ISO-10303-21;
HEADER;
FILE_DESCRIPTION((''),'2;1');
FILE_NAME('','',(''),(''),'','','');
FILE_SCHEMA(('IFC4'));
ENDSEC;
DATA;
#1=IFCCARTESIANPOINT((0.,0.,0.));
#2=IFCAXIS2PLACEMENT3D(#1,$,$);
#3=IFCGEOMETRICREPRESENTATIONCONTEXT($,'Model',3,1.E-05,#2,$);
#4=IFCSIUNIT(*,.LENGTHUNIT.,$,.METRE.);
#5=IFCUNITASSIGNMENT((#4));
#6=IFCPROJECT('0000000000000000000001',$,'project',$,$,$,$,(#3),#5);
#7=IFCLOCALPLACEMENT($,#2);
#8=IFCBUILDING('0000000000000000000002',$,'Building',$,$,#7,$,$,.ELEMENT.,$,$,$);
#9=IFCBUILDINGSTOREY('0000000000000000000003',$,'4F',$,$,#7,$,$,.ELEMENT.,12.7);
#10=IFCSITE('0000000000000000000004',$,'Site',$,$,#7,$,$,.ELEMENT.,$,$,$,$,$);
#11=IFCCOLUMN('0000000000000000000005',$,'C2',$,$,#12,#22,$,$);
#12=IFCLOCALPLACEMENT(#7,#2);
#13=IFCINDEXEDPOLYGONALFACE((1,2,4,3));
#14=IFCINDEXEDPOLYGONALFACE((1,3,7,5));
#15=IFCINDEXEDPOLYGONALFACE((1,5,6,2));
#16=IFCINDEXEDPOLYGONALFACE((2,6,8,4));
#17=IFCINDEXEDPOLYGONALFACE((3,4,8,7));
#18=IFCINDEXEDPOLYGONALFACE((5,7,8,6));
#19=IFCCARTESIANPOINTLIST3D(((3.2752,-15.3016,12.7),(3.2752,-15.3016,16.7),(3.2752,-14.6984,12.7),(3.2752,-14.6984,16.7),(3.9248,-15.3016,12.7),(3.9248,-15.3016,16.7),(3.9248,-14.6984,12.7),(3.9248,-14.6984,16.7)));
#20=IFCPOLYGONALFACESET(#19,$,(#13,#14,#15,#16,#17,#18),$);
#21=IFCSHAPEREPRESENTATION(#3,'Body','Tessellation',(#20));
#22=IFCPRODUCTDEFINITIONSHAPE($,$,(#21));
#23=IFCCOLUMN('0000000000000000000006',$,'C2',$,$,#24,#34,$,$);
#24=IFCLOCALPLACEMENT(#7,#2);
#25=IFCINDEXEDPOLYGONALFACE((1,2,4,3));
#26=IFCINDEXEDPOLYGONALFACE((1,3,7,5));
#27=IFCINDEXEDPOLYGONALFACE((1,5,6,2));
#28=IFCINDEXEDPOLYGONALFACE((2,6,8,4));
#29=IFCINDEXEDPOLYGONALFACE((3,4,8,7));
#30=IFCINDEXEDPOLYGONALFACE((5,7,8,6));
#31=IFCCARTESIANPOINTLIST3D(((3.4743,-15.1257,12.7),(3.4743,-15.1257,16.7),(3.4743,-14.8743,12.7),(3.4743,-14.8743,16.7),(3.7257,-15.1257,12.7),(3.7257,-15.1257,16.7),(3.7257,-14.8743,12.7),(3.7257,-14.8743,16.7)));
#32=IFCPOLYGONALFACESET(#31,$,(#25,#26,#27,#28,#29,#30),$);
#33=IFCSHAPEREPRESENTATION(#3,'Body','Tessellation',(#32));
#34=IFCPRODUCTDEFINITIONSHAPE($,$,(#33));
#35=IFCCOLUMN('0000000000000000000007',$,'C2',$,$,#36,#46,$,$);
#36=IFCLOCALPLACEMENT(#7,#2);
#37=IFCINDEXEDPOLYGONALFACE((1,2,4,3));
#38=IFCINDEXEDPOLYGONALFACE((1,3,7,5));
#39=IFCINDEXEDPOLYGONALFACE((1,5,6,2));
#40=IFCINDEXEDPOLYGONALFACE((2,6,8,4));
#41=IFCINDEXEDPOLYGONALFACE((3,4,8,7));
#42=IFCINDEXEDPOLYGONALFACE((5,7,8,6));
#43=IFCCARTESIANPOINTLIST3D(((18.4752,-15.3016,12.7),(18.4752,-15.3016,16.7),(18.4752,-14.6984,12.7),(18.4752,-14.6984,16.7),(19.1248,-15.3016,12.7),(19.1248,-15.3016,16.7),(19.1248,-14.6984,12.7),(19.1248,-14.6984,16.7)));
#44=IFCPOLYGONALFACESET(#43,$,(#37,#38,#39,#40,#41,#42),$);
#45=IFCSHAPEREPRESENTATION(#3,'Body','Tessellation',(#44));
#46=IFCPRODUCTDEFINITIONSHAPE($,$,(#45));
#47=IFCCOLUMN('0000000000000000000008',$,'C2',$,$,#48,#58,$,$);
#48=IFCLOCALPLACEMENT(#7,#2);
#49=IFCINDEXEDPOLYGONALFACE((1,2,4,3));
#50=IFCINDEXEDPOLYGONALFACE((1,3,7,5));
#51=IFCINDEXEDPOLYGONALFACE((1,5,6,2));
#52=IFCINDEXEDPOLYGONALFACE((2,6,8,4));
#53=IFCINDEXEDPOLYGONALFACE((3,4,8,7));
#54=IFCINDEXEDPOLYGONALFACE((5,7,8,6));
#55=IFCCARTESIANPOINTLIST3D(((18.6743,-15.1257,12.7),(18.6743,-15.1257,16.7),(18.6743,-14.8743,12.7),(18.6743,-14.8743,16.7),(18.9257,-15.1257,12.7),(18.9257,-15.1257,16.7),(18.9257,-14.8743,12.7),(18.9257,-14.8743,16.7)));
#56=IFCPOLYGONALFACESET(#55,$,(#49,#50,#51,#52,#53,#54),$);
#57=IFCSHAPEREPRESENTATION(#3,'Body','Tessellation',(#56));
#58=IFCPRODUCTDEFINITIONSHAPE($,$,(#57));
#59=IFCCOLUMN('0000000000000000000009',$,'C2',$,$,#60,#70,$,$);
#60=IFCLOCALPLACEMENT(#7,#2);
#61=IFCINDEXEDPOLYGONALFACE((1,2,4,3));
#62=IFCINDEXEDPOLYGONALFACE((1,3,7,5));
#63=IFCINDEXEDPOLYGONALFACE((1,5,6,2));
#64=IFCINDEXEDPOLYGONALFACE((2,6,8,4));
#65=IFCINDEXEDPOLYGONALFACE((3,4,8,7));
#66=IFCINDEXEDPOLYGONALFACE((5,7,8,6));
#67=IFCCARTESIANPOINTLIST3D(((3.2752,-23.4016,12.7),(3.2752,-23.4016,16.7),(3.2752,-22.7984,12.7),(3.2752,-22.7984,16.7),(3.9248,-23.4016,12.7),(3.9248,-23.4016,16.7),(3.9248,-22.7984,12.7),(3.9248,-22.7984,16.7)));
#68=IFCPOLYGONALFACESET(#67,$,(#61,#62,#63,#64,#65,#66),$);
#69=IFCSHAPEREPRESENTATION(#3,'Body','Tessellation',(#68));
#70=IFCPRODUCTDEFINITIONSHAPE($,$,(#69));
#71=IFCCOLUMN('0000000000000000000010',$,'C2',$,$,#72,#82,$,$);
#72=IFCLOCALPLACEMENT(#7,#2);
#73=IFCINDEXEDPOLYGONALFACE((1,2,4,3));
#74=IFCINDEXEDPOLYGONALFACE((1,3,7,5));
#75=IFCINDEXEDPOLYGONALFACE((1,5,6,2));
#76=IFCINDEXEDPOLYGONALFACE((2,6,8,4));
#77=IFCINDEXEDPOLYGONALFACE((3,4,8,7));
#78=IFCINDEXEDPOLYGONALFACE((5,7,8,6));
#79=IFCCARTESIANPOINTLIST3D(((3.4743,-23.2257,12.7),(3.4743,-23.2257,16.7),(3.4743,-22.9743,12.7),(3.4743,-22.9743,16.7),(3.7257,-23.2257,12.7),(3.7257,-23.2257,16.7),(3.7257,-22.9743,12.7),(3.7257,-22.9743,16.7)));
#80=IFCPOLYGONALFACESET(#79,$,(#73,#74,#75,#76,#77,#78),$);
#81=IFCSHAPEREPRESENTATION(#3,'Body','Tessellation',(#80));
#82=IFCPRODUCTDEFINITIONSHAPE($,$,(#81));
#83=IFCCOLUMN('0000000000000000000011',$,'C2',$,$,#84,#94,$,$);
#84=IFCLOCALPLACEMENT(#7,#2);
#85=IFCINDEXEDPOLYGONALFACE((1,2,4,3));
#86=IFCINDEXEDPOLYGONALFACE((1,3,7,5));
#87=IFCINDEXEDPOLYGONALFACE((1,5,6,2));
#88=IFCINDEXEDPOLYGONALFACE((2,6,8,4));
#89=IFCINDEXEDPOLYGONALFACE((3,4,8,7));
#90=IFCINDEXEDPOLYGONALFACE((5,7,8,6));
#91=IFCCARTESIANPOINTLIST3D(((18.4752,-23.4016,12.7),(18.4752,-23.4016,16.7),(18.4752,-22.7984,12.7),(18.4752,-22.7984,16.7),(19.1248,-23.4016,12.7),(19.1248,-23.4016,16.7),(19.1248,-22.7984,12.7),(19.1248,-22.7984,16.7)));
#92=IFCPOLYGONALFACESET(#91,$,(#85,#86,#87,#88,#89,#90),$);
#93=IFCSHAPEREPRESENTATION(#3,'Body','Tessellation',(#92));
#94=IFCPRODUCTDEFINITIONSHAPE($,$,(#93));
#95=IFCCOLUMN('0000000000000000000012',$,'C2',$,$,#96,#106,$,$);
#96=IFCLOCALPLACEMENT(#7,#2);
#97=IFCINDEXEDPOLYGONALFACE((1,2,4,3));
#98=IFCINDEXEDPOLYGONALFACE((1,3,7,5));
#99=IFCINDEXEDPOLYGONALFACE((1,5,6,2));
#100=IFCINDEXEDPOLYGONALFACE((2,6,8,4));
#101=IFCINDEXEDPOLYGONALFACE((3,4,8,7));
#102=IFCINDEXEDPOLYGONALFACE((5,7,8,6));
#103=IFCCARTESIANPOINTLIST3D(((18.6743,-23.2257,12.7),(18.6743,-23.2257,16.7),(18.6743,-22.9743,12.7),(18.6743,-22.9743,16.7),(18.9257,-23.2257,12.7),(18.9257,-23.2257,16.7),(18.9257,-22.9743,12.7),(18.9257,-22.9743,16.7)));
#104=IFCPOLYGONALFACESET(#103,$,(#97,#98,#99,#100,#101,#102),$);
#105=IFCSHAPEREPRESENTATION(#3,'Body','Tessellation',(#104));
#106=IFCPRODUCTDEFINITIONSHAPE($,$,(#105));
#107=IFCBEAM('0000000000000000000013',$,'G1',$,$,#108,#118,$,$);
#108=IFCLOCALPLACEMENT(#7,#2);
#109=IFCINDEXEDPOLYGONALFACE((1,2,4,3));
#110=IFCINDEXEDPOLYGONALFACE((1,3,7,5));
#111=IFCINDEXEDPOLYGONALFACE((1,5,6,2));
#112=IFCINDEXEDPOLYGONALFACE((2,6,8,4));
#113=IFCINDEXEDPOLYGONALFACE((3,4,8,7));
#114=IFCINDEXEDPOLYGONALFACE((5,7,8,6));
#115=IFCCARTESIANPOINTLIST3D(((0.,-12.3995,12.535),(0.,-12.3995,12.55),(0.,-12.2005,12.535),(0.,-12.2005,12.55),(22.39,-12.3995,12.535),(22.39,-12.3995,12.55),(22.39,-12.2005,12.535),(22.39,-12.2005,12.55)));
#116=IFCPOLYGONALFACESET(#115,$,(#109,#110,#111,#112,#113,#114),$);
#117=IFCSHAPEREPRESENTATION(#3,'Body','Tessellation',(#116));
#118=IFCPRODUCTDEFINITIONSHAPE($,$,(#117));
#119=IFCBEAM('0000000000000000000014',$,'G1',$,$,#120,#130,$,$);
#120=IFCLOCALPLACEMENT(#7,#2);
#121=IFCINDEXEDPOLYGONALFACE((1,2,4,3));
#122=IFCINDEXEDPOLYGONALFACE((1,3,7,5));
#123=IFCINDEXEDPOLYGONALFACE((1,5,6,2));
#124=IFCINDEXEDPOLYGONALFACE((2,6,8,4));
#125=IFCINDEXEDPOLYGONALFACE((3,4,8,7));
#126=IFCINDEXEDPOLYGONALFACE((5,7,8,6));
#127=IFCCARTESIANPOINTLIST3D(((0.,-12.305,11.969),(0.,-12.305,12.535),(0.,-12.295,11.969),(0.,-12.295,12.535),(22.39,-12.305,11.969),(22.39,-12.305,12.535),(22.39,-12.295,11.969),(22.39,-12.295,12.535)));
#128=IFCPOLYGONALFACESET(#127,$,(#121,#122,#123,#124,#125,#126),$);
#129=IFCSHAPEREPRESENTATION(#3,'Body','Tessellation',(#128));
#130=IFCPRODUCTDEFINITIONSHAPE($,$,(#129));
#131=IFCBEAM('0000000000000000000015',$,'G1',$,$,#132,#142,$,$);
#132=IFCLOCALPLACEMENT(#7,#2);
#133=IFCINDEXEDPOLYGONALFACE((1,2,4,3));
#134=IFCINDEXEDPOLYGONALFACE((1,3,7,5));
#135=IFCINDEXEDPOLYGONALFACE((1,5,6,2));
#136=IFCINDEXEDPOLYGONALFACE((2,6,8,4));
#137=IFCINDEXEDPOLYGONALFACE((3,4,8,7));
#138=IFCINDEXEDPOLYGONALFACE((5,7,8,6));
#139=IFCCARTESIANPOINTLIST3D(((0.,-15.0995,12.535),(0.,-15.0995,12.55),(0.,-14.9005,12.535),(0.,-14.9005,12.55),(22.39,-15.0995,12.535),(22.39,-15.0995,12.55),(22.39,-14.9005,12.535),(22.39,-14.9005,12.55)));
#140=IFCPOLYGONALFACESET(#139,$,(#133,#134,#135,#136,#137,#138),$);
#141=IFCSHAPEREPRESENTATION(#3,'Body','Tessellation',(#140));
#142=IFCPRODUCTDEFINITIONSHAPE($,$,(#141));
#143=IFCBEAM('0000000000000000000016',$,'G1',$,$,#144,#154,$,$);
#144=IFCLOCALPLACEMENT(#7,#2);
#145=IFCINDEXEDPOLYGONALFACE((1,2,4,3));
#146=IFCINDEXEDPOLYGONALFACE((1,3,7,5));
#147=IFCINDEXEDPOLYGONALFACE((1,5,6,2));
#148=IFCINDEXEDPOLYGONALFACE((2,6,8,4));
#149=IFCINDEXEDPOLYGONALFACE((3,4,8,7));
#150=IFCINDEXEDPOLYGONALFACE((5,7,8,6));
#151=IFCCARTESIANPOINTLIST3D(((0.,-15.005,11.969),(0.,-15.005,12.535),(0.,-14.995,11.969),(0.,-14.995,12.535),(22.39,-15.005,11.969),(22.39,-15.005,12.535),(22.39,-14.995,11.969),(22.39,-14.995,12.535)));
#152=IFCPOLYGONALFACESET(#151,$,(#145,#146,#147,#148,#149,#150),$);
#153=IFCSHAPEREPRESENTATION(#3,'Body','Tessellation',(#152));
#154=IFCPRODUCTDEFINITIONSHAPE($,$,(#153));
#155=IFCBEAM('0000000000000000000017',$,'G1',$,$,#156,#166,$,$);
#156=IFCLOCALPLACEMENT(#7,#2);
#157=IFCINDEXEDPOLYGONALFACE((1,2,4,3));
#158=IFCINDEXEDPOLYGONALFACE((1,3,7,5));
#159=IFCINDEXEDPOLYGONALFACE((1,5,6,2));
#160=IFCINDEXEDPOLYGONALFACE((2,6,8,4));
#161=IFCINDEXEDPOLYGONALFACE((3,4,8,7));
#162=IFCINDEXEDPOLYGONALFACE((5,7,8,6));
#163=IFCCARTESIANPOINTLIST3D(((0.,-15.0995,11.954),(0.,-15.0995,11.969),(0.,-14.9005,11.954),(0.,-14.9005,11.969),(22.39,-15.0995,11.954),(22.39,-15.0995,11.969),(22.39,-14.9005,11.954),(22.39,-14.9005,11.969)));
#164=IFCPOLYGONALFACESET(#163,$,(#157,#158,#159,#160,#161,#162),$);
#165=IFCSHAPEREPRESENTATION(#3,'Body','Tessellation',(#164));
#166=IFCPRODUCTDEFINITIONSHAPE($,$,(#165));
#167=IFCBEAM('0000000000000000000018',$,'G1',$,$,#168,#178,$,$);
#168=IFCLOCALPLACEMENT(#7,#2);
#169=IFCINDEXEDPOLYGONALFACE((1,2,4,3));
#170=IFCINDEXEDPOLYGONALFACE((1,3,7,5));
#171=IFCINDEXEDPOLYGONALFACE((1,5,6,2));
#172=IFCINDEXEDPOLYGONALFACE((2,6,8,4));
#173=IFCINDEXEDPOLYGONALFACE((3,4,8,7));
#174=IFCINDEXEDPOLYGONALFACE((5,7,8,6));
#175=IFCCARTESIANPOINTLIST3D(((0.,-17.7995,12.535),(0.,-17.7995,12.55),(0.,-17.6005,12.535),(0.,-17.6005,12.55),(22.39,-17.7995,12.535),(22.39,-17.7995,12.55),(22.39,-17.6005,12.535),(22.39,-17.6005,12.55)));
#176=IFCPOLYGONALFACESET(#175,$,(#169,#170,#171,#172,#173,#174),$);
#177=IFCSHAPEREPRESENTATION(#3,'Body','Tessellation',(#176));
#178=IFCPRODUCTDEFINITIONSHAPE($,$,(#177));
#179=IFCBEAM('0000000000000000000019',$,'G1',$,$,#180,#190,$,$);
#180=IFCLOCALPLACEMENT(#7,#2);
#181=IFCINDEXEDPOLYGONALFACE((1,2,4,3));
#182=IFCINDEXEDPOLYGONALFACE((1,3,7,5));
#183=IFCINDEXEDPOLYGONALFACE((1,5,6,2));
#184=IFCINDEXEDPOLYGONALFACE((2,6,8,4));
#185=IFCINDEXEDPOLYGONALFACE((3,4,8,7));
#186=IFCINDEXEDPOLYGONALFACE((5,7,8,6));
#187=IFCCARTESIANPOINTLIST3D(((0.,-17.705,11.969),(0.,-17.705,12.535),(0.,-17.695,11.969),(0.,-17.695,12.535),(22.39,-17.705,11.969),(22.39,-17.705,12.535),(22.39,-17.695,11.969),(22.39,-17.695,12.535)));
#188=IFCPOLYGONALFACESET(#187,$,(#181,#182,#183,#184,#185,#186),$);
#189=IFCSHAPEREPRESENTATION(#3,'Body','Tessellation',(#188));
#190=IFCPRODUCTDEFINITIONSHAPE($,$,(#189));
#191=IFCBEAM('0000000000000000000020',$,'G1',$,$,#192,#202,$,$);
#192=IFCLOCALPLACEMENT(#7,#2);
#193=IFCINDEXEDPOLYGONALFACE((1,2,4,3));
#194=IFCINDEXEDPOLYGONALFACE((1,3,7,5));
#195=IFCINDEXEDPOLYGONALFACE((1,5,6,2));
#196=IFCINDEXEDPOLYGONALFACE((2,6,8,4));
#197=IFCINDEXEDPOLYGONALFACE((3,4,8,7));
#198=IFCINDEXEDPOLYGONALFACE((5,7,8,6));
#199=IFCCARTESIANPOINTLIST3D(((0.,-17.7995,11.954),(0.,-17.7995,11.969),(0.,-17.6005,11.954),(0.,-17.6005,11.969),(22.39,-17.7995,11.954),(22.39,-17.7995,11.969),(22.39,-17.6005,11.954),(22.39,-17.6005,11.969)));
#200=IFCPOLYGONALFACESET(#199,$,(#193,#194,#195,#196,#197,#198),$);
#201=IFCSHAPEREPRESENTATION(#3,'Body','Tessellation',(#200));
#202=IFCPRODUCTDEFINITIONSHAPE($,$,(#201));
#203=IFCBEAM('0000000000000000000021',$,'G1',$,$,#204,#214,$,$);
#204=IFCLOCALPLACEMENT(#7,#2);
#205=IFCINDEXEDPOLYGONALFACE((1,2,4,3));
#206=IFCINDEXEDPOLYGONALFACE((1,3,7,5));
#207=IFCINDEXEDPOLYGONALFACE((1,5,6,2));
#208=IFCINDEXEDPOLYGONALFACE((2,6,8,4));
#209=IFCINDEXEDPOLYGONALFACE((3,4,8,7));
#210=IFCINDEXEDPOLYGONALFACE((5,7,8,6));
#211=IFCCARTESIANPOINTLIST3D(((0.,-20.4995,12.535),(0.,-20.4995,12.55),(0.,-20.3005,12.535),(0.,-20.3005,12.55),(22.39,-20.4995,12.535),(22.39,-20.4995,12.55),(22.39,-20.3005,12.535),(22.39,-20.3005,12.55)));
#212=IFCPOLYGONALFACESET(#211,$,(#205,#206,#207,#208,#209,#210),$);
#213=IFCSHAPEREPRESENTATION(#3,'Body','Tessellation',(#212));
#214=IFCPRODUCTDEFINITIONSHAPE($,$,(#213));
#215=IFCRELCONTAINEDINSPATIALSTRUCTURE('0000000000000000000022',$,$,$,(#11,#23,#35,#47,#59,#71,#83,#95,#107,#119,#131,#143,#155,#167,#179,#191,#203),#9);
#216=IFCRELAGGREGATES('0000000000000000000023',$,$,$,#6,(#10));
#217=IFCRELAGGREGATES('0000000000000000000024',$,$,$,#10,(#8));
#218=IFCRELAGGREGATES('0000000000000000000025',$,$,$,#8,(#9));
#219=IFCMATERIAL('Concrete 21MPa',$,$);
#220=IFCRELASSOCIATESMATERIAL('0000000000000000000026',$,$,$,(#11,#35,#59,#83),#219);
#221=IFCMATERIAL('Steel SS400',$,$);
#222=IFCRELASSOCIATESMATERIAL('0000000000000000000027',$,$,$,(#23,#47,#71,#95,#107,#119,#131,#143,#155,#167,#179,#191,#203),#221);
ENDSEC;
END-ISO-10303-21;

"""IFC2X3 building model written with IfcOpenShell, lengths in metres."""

from ifc_helpers import new_model, si_unit, frame, origin, origin_2d, place, context, project, spatial, rectangle, extrude, material, element, save


model = new_model("IFC2X3")

# Units and contexts
model_context = context("Model", 3, precision=1e-05, world=origin())
ifc_project = project(units=[si_unit("LENGTHUNIT", "METRE")], contexts=[model_context])

# Site, building, storey
placement = place(None, origin())
site = spatial("IfcSite", under=ifc_project, at=placement, Name="Site", CompositionType="ELEMENT")
building = spatial("IfcBuilding", under=site, at=placement, Name="Building", CompositionType="ELEMENT")
storey = spatial("IfcBuildingStorey", under=building, at=placement, Name="4F", CompositionType="ELEMENT", Elevation=12.7)

# Columns
ifc_material_1 = material(Name="Concrete 21MPa")
column_1_placement = place(None, frame((3.6, -15.0, 12.7)))
element("IfcColumn", 1, at=column_1_placement, inside=storey, material=ifc_material_1, Name="C2", context=model_context, shape_type="SweptSolid", body=[
    extrude(rectangle(XDim=0.6496, YDim=0.6032, at=origin_2d()), origin(), (0.0, 0.0, 1.0), 4.0),
])
ifc_material_2 = material(Name="Steel SS400")
column_2_placement = place(None, frame((3.6, -15.0, 12.7)))
element("IfcColumn", 2, at=column_2_placement, inside=storey, material=ifc_material_2, Name="C2", context=model_context, shape_type="SweptSolid", body=[
    extrude(rectangle(XDim=0.2513, YDim=0.2513, at=origin_2d()), origin(), (0.0, 0.0, 1.0), 4.0),
])
column_3_placement = place(None, frame((18.8, -15.0, 12.7)))
element("IfcColumn", 3, at=column_3_placement, inside=storey, material=ifc_material_1, Name="C2", context=model_context, shape_type="SweptSolid", body=[
    extrude(rectangle(XDim=0.6496, YDim=0.6032, at=origin_2d()), origin(), (0.0, 0.0, 1.0), 4.0),
])
column_4_placement = place(None, frame((18.8, -15.0, 12.7)))
element("IfcColumn", 4, at=column_4_placement, inside=storey, material=ifc_material_2, Name="C2", context=model_context, shape_type="SweptSolid", body=[
    extrude(rectangle(XDim=0.2513, YDim=0.2513, at=origin_2d()), origin(), (0.0, 0.0, 1.0), 4.0),
])
column_5_placement = place(None, frame((3.6, -23.1, 12.7)))
element("IfcColumn", 5, at=column_5_placement, inside=storey, material=ifc_material_1, Name="C2", context=model_context, shape_type="SweptSolid", body=[
    extrude(rectangle(XDim=0.6496, YDim=0.6032, at=origin_2d()), origin(), (0.0, 0.0, 1.0), 4.0),
])
column_6_placement = place(None, frame((3.6, -23.1, 12.7)))
element("IfcColumn", 6, at=column_6_placement, inside=storey, material=ifc_material_2, Name="C2", context=model_context, shape_type="SweptSolid", body=[
    extrude(rectangle(XDim=0.2513, YDim=0.2513, at=origin_2d()), origin(), (0.0, 0.0, 1.0), 4.0),
])
column_7_placement = place(None, frame((18.8, -23.1, 12.7)))
element("IfcColumn", 7, at=column_7_placement, inside=storey, material=ifc_material_1, Name="C2", context=model_context, shape_type="SweptSolid", body=[
    extrude(rectangle(XDim=0.6496, YDim=0.6032, at=origin_2d()), origin(), (0.0, 0.0, 1.0), 4.0),
])
column_8_placement = place(None, frame((18.8, -23.1, 12.7)))
element("IfcColumn", 8, at=column_8_placement, inside=storey, material=ifc_material_2, Name="C2", context=model_context, shape_type="SweptSolid", body=[
    extrude(rectangle(XDim=0.2513, YDim=0.2513, at=origin_2d()), origin(), (0.0, 0.0, 1.0), 4.0),
])

# Beams
beam_1_placement = place(None, frame((11.195, -12.3, 12.535)))
element("IfcBeam", 9, at=beam_1_placement, inside=storey, material=ifc_material_2, Name="G1", context=model_context, shape_type="SweptSolid", body=[
    extrude(rectangle(XDim=22.39, YDim=0.199, at=origin_2d()), origin(), (0.0, 0.0, 1.0), 0.015),
])
beam_2_placement = place(None, frame((11.195, -12.3, 11.969)))
element("IfcBeam", 10, at=beam_2_placement, inside=storey, material=ifc_material_2, Name="G1", context=model_context, shape_type="SweptSolid", body=[
    extrude(rectangle(XDim=22.39, YDim=0.01, at=origin_2d()), origin(), (0.0, 0.0, 1.0), 0.566),
])
beam_3_placement = place(None, frame((11.195, -15.0, 12.535)))
element("IfcBeam", 11, at=beam_3_placement, inside=storey, material=ifc_material_2, Name="G1", context=model_context, shape_type="SweptSolid", body=[
    extrude(rectangle(XDim=22.39, YDim=0.199, at=origin_2d()), origin(), (0.0, 0.0, 1.0), 0.015),
])
beam_4_placement = place(None, frame((11.195, -15.0, 11.969)))
element("IfcBeam", 12, at=beam_4_placement, inside=storey, material=ifc_material_2, Name="G1", context=model_context, shape_type="SweptSolid", body=[
    extrude(rectangle(XDim=22.39, YDim=0.01, at=origin_2d()), origin(), (0.0, 0.0, 1.0), 0.566),
])
for number, where, name in (
    (13, (11.195, -15.0, 11.954), "G1"),
    (14, (11.195, -17.7, 12.535), "G1"),
):
    element("IfcBeam", number, at=place(None, frame(where)), inside=storey, material=ifc_material_2, Name=name, context=model_context, shape_type="SweptSolid", body=[
        extrude(rectangle(XDim=22.39, YDim=0.199, at=origin_2d()), origin(), (0.0, 0.0, 1.0), 0.015),
    ])
beam_5_placement = place(None, frame((11.195, -17.7, 11.969)))
element("IfcBeam", 15, at=beam_5_placement, inside=storey, material=ifc_material_2, Name="G1", context=model_context, shape_type="SweptSolid", body=[
    extrude(rectangle(XDim=22.39, YDim=0.01, at=origin_2d()), origin(), (0.0, 0.0, 1.0), 0.566),
])
for number, where, name in (
    (16, (11.195, -17.7, 11.954), "G1"),
    (17, (11.195, -20.4, 12.535), "G1"),
):
    element("IfcBeam", number, at=place(None, frame(where)), inside=storey, material=ifc_material_2, Name=name, context=model_context, shape_type="SweptSolid", body=[
        extrude(rectangle(XDim=22.39, YDim=0.199, at=origin_2d()), origin(), (0.0, 0.0, 1.0), 0.015),
    ])

save(model, "model.ifc")
